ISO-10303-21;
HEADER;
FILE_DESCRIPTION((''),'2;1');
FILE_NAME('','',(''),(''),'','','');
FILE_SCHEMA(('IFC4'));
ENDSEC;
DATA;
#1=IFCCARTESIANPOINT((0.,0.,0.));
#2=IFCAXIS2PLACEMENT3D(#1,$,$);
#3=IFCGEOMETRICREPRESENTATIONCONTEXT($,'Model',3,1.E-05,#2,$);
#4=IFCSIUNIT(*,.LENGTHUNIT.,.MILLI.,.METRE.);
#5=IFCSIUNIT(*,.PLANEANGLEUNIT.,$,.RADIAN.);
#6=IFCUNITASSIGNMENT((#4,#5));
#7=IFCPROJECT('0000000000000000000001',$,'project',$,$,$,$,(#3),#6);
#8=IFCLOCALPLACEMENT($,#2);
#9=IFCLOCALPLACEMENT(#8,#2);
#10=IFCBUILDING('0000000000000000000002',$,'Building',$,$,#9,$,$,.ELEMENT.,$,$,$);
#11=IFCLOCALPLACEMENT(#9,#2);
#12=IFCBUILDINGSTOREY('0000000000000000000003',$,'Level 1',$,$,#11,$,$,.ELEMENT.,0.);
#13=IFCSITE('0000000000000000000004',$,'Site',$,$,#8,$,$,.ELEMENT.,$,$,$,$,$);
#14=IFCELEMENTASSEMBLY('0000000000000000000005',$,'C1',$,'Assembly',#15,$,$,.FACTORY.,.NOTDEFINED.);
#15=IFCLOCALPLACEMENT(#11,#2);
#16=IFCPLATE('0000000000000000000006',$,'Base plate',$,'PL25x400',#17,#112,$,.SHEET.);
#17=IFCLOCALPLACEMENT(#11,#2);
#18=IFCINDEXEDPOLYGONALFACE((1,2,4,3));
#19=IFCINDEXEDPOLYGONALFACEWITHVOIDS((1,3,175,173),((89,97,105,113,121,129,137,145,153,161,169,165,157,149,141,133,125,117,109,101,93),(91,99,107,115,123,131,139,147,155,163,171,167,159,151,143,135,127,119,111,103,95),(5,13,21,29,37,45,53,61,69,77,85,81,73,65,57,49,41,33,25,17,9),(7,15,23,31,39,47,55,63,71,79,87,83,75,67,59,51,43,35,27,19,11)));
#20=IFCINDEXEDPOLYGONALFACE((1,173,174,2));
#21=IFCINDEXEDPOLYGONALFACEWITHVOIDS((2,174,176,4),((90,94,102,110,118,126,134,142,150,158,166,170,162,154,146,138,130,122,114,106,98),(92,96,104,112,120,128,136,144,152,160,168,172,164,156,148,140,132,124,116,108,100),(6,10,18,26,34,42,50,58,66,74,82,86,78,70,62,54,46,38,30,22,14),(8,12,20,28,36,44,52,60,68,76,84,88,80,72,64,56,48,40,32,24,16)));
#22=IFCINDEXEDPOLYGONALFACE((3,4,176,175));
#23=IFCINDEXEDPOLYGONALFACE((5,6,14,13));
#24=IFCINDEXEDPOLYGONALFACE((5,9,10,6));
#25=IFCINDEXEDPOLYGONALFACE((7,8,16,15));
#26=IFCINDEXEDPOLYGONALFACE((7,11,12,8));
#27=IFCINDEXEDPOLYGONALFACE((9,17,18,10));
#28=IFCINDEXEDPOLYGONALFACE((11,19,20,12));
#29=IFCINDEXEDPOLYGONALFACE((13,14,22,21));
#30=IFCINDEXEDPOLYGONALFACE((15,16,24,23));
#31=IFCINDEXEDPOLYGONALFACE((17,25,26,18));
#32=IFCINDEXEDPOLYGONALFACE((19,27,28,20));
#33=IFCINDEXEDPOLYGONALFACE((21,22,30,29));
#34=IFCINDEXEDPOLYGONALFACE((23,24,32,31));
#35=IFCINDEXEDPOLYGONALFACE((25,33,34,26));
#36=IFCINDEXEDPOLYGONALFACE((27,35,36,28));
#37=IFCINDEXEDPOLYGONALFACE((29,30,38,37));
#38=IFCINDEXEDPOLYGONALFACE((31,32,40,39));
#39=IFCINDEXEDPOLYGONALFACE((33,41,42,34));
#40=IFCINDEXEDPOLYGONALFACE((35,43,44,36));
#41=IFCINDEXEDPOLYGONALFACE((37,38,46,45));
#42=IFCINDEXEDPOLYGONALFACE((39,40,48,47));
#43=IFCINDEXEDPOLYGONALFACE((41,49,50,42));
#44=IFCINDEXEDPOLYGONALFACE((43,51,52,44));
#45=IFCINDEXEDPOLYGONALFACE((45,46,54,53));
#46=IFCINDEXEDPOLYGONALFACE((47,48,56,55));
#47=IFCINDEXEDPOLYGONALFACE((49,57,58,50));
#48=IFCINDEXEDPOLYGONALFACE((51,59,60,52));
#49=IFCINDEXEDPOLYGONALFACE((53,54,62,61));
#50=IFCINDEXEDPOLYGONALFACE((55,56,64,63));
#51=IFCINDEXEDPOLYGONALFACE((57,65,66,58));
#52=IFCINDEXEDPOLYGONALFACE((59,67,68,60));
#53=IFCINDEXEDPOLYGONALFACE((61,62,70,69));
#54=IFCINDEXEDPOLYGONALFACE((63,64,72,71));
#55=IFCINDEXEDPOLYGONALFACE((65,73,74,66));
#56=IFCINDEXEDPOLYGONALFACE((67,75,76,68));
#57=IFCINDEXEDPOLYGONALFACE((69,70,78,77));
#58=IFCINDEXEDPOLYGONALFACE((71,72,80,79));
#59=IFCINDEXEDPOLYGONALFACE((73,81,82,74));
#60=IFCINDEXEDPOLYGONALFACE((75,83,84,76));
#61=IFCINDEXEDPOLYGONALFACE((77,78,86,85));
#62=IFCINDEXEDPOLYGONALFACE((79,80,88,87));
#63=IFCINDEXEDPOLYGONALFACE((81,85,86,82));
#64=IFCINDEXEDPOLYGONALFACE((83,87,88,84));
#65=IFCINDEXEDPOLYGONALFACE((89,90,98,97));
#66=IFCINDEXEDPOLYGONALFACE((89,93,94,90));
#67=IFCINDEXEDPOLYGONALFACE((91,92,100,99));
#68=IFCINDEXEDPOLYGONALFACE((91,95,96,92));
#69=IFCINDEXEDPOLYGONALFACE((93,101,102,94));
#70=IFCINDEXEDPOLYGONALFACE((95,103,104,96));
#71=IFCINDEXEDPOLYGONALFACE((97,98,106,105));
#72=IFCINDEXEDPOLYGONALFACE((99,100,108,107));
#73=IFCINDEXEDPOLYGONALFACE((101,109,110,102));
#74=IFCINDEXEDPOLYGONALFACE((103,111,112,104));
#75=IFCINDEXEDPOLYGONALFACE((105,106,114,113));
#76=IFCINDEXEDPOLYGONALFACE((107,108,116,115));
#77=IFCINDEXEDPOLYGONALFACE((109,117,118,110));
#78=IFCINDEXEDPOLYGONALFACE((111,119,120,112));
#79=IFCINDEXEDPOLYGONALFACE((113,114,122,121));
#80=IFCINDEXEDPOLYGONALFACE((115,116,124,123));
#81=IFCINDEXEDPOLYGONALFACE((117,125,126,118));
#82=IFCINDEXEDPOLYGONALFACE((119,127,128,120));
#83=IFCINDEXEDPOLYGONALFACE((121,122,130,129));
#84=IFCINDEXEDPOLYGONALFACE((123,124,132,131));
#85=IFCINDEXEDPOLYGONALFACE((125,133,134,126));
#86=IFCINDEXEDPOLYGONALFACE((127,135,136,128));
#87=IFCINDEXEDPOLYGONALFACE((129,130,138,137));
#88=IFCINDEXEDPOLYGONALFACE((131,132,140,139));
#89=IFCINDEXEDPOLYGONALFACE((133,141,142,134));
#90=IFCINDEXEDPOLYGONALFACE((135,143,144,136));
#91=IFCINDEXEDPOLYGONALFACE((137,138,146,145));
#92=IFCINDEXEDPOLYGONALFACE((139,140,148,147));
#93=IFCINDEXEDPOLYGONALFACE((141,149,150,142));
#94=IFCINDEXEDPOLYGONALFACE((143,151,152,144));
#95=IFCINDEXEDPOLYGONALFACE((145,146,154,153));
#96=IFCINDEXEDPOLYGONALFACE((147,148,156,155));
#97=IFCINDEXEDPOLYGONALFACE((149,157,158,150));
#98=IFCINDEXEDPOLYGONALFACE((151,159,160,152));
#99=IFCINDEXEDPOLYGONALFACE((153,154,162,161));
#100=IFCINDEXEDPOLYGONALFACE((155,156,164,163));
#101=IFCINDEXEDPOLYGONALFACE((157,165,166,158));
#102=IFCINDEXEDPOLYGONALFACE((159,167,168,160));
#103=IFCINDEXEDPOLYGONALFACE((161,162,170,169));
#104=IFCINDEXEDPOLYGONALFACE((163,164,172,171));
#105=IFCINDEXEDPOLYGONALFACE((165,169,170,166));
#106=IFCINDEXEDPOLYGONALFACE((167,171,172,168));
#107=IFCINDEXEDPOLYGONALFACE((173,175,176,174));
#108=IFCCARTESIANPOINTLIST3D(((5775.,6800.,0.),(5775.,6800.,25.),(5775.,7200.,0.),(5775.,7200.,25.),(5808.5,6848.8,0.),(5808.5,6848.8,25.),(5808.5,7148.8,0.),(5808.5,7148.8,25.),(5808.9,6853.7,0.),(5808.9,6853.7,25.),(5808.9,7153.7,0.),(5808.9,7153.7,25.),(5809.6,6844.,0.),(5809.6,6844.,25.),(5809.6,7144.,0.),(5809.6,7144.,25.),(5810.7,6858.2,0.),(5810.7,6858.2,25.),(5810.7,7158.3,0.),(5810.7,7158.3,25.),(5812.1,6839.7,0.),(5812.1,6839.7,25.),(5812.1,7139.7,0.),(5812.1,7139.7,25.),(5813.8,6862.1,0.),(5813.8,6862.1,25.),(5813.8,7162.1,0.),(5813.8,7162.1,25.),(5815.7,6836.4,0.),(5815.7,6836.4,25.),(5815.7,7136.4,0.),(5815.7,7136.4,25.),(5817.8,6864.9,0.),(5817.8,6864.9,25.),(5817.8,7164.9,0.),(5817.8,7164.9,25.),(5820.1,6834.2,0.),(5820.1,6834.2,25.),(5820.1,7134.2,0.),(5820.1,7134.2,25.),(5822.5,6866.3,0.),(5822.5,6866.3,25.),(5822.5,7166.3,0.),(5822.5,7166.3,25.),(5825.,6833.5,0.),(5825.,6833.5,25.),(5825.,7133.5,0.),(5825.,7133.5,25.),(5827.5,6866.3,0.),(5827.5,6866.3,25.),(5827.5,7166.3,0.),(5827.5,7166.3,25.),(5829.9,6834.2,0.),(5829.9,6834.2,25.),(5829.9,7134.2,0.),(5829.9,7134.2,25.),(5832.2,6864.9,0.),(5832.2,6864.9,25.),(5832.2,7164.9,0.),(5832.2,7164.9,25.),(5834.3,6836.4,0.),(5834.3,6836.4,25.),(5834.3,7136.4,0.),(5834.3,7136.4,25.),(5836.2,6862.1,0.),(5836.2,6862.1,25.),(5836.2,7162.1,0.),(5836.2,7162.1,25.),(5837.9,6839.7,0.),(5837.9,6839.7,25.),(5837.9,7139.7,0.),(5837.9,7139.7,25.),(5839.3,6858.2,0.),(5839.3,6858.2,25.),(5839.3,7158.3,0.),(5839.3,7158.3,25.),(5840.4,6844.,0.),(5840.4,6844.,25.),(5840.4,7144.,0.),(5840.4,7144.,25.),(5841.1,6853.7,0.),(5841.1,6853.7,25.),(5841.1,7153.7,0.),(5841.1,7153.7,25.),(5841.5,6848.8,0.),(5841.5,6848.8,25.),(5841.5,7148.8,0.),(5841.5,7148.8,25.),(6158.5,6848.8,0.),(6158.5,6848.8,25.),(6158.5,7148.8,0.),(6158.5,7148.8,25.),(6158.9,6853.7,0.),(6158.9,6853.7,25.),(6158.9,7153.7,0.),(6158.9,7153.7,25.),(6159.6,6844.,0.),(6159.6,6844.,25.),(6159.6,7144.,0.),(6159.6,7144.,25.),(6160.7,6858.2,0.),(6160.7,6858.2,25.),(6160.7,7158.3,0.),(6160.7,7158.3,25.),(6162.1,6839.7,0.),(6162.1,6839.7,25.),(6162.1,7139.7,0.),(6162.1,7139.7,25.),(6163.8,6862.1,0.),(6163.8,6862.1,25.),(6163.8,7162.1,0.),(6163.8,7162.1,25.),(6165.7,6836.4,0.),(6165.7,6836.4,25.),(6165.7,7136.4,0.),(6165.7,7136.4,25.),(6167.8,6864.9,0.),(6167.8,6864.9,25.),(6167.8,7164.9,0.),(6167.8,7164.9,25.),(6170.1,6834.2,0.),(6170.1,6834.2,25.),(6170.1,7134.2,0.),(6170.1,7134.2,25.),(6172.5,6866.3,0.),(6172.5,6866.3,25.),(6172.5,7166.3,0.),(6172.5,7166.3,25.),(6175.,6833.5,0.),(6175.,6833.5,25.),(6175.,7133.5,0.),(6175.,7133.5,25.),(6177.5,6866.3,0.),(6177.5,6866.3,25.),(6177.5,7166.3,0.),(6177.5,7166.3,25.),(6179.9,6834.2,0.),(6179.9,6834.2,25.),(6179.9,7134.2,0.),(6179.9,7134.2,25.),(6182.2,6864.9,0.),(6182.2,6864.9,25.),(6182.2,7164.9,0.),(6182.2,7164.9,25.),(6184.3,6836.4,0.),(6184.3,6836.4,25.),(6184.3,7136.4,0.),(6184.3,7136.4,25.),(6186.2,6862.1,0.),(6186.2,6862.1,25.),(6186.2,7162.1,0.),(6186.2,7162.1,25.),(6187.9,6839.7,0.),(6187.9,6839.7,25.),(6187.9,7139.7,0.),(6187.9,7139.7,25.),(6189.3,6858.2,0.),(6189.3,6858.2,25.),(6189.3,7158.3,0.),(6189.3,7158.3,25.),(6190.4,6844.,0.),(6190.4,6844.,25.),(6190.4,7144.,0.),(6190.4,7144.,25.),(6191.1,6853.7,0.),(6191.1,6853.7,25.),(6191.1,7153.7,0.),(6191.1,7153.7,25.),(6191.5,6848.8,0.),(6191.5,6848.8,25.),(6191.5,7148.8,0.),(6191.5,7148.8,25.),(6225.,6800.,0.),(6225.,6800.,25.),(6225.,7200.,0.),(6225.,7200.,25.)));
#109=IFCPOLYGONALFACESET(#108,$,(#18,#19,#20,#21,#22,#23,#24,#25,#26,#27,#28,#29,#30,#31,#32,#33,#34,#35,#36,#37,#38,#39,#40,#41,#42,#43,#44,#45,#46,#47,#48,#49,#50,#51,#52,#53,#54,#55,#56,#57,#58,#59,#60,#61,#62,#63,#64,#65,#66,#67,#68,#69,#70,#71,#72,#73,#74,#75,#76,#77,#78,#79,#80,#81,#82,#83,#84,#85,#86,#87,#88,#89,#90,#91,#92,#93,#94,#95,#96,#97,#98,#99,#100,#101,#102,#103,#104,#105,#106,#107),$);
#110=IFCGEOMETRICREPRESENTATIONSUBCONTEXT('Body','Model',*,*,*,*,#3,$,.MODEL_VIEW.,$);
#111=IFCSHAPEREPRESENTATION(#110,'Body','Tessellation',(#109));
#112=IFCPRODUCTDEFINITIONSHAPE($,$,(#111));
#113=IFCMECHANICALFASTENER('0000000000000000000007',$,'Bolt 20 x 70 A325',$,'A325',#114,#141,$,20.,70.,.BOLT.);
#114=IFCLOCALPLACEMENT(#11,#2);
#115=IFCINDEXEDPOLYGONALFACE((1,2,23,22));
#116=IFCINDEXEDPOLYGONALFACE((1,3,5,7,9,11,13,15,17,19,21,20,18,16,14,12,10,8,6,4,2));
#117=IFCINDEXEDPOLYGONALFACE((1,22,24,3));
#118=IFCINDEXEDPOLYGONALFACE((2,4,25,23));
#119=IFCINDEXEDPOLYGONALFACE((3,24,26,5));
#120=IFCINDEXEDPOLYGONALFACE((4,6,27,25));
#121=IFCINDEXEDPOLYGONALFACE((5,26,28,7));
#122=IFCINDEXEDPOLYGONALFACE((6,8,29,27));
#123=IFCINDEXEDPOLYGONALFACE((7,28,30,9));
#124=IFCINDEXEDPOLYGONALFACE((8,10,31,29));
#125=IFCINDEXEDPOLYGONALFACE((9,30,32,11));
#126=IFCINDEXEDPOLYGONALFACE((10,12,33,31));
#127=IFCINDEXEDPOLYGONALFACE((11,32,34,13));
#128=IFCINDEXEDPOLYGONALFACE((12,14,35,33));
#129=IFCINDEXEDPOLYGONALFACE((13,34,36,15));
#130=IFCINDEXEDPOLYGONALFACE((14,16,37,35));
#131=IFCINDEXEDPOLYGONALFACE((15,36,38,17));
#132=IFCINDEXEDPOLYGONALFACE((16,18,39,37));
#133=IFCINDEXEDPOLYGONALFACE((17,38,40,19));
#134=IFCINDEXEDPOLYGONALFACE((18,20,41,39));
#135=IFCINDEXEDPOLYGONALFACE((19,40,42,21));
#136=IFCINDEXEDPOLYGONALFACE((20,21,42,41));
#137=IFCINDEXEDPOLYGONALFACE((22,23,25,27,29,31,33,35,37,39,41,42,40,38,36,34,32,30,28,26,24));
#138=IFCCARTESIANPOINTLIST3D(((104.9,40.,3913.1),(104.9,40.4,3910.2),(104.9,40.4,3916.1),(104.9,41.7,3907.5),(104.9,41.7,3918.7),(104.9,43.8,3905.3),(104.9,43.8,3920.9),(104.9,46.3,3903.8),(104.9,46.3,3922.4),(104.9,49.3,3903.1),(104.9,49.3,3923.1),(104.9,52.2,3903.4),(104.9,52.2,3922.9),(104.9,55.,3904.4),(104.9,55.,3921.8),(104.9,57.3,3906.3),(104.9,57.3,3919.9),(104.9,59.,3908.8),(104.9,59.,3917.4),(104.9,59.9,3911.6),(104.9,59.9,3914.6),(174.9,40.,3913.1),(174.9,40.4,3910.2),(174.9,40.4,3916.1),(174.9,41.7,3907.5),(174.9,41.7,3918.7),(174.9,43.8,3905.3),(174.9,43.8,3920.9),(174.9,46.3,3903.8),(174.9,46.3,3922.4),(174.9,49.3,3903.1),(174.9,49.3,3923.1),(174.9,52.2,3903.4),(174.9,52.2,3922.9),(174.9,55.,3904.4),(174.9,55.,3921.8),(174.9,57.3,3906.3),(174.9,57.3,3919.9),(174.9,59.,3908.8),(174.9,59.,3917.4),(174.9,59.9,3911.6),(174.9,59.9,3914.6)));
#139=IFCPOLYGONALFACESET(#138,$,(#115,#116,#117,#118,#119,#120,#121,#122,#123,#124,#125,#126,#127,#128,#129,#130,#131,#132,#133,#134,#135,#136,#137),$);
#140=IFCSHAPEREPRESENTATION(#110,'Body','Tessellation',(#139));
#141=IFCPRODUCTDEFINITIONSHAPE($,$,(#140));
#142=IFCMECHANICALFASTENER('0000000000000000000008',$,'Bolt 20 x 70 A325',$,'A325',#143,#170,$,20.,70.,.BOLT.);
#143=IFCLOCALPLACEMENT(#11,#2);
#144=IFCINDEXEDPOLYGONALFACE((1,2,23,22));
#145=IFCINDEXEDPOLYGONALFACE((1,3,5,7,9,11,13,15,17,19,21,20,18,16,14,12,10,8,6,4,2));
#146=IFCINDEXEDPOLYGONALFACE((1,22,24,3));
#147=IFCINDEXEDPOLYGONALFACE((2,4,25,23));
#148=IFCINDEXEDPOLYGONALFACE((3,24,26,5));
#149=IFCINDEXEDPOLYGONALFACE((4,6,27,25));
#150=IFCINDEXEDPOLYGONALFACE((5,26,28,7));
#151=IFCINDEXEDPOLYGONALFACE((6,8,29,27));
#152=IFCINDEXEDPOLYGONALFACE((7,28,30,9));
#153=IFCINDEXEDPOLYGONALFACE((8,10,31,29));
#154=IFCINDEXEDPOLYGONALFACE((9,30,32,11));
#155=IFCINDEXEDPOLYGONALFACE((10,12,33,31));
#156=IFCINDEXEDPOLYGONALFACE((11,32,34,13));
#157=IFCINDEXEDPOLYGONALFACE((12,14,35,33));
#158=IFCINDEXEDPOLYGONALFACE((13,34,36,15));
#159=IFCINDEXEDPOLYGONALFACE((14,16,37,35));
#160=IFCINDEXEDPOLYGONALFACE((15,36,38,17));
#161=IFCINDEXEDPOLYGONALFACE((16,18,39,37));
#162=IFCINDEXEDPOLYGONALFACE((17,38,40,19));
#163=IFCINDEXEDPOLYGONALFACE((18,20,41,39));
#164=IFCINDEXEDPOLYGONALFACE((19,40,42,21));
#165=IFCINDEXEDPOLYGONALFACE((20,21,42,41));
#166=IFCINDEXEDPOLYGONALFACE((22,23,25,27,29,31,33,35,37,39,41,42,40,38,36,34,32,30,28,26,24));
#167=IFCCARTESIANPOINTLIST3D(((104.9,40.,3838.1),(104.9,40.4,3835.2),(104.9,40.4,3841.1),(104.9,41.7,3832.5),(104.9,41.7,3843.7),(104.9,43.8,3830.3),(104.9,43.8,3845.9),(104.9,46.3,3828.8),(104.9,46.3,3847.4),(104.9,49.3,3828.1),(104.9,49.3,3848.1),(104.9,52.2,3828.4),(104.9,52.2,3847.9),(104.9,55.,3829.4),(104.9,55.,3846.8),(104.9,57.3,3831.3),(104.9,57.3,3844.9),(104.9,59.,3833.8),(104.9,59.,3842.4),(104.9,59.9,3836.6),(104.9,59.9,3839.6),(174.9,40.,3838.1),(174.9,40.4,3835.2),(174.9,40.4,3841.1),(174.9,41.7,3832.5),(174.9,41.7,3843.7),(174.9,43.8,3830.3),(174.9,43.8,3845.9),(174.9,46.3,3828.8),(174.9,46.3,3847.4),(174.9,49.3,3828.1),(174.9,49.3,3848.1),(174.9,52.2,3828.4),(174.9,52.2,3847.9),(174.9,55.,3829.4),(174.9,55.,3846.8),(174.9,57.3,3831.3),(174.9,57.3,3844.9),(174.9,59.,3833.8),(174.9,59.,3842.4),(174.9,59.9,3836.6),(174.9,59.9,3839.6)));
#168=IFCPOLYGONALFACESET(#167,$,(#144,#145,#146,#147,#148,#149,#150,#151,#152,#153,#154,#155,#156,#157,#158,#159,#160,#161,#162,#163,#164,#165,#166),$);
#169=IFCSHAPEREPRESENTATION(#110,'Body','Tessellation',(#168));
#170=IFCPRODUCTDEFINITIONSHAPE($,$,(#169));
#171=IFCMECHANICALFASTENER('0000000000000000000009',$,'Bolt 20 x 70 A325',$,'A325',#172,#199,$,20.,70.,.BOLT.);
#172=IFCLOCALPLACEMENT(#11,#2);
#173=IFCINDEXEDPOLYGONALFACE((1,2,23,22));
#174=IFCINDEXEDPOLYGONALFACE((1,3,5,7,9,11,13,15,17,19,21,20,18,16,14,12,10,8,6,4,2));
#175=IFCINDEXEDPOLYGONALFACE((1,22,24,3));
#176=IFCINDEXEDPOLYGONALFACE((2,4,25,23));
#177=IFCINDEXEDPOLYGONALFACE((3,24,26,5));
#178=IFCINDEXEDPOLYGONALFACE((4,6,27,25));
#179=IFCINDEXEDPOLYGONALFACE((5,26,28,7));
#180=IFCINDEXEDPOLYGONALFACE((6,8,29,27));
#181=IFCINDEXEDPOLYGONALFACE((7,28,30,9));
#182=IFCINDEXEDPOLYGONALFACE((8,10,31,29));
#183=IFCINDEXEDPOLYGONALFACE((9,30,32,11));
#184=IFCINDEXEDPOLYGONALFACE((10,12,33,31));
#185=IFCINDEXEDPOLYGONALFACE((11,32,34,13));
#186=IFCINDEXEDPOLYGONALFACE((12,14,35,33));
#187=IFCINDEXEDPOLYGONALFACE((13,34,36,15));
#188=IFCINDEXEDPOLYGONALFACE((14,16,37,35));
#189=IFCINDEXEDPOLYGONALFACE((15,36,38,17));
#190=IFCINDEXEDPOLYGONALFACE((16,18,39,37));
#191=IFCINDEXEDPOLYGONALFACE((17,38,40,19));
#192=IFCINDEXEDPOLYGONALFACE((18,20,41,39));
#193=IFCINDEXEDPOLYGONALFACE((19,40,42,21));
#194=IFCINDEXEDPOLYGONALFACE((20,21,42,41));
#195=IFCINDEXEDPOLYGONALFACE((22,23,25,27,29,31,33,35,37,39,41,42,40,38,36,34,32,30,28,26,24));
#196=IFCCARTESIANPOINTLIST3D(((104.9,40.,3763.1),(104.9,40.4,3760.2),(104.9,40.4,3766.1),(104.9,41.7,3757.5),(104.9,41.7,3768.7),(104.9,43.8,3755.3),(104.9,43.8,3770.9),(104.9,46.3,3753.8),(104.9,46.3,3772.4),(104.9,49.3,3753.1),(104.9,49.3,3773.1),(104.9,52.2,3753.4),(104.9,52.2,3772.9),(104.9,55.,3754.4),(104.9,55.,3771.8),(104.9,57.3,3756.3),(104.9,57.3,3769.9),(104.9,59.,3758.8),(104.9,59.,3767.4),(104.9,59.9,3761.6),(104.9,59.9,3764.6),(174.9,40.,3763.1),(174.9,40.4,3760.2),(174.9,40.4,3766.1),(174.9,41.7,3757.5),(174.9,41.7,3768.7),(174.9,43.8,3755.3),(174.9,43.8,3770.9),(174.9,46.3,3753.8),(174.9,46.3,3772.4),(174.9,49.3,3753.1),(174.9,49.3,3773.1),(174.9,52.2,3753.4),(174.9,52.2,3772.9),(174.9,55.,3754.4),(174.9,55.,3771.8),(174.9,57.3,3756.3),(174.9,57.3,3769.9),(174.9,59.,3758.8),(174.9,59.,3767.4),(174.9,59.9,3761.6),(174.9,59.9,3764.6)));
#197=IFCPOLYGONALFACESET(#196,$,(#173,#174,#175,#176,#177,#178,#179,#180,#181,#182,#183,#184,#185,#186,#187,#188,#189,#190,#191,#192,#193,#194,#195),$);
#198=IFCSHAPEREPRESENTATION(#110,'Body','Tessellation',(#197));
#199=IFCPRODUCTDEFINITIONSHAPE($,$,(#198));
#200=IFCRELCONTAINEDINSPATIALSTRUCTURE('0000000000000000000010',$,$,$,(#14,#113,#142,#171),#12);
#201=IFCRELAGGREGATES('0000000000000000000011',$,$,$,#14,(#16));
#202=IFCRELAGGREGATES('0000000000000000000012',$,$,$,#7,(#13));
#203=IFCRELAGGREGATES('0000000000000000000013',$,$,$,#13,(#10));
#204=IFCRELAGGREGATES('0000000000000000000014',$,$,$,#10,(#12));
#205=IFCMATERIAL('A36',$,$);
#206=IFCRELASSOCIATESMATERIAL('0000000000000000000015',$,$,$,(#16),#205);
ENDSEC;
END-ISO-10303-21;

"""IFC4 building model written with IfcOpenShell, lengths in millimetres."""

from ifc_helpers import new_model, si_unit, frame, origin, origin_2d, place, context, subcontext, project, spatial, rectangle, circle, extrude, material, element, aggregate, save


model = new_model("IFC4")

# Units and contexts
model_context = context("Model", 3, precision=1e-05, world=origin())
body_context = subcontext(model_context, "Body", "Model", "MODEL_VIEW")
ifc_project = project(units=[si_unit("LENGTHUNIT", "METRE", prefix="MILLI"), si_unit("PLANEANGLEUNIT", "RADIAN")], contexts=[model_context])

# Site, building, storey
site_placement = place(None, origin())
site = spatial("IfcSite", under=ifc_project, at=site_placement, Name="Site", CompositionType="ELEMENT")
building_placement = place(site_placement, origin())
building = spatial("IfcBuilding", under=site, at=building_placement, Name="Building", CompositionType="ELEMENT")
storey_placement = place(building_placement, origin())
storey = spatial("IfcBuildingStorey", under=building, at=storey_placement, Name="Level 1", CompositionType="ELEMENT", Elevation=0.0)

# Element assembly, plate, openings
ifc_material = material(Name="A36")
assembly_1_placement = place(storey_placement, origin())
assembly_1 = element("IfcElementAssembly", 1, at=assembly_1_placement, inside=storey, Name="C1", ObjectType="Assembly", AssemblyPlace="FACTORY", PredefinedType="NOTDEFINED")
plate_1_placement = place(storey_placement, frame((5775.0, 7000.0, 12.5), z_axis=(1.0, 0.0, 0.0), x_axis=(0.0, 1.0, 0.0)))
plate_1 = element("IfcPlate", 2, at=plate_1_placement, material=ifc_material, Name="Base plate", ObjectType="PL25x400", PredefinedType="SHEET", context=body_context, shape_type="SweptSolid", body=[
    extrude(rectangle(XDim=400.0, YDim=25.0, at=origin_2d()), origin(), (0.0, 0.0, 1.0), 450.0),
])
opening_1_placement = place(plate_1_placement, frame((-150.0, -13.5, 50.0), z_axis=(0.0, 1.0, 0.0), x_axis=(-1.0, 0.0, 0.0)))
element("IfcOpeningElement", 3, at=opening_1_placement, cuts=plate_1, PredefinedType="OPENING", context=body_context, shape_type="SweptSolid", body=[
    extrude(circle(Radius=16.5, at=origin_2d()), origin(), (0.0, 0.0, 1.0), 27.0),
])
opening_2_placement = place(plate_1_placement, frame((150.0, -13.5, 50.0), z_axis=(0.0, 1.0, 0.0), x_axis=(-1.0, 0.0, 0.0)))
element("IfcOpeningElement", 4, at=opening_2_placement, cuts=plate_1, PredefinedType="OPENING", context=body_context, shape_type="SweptSolid", body=[
    extrude(circle(Radius=16.5, at=origin_2d()), origin(), (0.0, 0.0, 1.0), 27.0),
])
opening_3_placement = place(plate_1_placement, frame((-150.0, -13.5, 400.0), z_axis=(0.0, 1.0, 0.0), x_axis=(-1.0, 0.0, 0.0)))
element("IfcOpeningElement", 5, at=opening_3_placement, cuts=plate_1, PredefinedType="OPENING", context=body_context, shape_type="SweptSolid", body=[
    extrude(circle(Radius=16.5, at=origin_2d()), origin(), (0.0, 0.0, 1.0), 27.0),
])
opening_4_placement = place(plate_1_placement, frame((150.0, -13.5, 400.0), z_axis=(0.0, 1.0, 0.0), x_axis=(-1.0, 0.0, 0.0)))
element("IfcOpeningElement", 6, at=opening_4_placement, cuts=plate_1, PredefinedType="OPENING", context=body_context, shape_type="SweptSolid", body=[
    extrude(circle(Radius=16.5, at=origin_2d()), origin(), (0.0, 0.0, 1.0), 27.0),
])
aggregate(assembly_1, [plate_1])

# Mechanical fasteners
for number, where, z_axis, x_axis, name in (
    (7, (174.9, 50.0, 3913.1), (-1.0, 0.0, 0.0), (0.0, -1.0, 0.0), "Bolt 20 x 70 A325"),
    (8, (174.9, 50.0, 3838.1), (-1.0, 0.0, 0.0), (0.0, -1.0, 0.0), "Bolt 20 x 70 A325"),
    (9, (174.9, 50.0, 3763.1), (-1.0, 0.0, 0.0), (0.0, -1.0, 0.0), "Bolt 20 x 70 A325"),
):
    element("IfcMechanicalFastener", number, at=place(storey_placement, frame(where, z_axis=z_axis, x_axis=x_axis)), inside=storey, Name=name, ObjectType="A325", NominalDiameter=20.0, NominalLength=70.0, PredefinedType="BOLT", context=body_context, shape_type="SweptSolid", body=[
        extrude(circle(Radius=10.0, at=origin_2d()), origin(), (0.0, 0.0, 1.0), 70.0),
    ])

save(model, "model.ifc")
